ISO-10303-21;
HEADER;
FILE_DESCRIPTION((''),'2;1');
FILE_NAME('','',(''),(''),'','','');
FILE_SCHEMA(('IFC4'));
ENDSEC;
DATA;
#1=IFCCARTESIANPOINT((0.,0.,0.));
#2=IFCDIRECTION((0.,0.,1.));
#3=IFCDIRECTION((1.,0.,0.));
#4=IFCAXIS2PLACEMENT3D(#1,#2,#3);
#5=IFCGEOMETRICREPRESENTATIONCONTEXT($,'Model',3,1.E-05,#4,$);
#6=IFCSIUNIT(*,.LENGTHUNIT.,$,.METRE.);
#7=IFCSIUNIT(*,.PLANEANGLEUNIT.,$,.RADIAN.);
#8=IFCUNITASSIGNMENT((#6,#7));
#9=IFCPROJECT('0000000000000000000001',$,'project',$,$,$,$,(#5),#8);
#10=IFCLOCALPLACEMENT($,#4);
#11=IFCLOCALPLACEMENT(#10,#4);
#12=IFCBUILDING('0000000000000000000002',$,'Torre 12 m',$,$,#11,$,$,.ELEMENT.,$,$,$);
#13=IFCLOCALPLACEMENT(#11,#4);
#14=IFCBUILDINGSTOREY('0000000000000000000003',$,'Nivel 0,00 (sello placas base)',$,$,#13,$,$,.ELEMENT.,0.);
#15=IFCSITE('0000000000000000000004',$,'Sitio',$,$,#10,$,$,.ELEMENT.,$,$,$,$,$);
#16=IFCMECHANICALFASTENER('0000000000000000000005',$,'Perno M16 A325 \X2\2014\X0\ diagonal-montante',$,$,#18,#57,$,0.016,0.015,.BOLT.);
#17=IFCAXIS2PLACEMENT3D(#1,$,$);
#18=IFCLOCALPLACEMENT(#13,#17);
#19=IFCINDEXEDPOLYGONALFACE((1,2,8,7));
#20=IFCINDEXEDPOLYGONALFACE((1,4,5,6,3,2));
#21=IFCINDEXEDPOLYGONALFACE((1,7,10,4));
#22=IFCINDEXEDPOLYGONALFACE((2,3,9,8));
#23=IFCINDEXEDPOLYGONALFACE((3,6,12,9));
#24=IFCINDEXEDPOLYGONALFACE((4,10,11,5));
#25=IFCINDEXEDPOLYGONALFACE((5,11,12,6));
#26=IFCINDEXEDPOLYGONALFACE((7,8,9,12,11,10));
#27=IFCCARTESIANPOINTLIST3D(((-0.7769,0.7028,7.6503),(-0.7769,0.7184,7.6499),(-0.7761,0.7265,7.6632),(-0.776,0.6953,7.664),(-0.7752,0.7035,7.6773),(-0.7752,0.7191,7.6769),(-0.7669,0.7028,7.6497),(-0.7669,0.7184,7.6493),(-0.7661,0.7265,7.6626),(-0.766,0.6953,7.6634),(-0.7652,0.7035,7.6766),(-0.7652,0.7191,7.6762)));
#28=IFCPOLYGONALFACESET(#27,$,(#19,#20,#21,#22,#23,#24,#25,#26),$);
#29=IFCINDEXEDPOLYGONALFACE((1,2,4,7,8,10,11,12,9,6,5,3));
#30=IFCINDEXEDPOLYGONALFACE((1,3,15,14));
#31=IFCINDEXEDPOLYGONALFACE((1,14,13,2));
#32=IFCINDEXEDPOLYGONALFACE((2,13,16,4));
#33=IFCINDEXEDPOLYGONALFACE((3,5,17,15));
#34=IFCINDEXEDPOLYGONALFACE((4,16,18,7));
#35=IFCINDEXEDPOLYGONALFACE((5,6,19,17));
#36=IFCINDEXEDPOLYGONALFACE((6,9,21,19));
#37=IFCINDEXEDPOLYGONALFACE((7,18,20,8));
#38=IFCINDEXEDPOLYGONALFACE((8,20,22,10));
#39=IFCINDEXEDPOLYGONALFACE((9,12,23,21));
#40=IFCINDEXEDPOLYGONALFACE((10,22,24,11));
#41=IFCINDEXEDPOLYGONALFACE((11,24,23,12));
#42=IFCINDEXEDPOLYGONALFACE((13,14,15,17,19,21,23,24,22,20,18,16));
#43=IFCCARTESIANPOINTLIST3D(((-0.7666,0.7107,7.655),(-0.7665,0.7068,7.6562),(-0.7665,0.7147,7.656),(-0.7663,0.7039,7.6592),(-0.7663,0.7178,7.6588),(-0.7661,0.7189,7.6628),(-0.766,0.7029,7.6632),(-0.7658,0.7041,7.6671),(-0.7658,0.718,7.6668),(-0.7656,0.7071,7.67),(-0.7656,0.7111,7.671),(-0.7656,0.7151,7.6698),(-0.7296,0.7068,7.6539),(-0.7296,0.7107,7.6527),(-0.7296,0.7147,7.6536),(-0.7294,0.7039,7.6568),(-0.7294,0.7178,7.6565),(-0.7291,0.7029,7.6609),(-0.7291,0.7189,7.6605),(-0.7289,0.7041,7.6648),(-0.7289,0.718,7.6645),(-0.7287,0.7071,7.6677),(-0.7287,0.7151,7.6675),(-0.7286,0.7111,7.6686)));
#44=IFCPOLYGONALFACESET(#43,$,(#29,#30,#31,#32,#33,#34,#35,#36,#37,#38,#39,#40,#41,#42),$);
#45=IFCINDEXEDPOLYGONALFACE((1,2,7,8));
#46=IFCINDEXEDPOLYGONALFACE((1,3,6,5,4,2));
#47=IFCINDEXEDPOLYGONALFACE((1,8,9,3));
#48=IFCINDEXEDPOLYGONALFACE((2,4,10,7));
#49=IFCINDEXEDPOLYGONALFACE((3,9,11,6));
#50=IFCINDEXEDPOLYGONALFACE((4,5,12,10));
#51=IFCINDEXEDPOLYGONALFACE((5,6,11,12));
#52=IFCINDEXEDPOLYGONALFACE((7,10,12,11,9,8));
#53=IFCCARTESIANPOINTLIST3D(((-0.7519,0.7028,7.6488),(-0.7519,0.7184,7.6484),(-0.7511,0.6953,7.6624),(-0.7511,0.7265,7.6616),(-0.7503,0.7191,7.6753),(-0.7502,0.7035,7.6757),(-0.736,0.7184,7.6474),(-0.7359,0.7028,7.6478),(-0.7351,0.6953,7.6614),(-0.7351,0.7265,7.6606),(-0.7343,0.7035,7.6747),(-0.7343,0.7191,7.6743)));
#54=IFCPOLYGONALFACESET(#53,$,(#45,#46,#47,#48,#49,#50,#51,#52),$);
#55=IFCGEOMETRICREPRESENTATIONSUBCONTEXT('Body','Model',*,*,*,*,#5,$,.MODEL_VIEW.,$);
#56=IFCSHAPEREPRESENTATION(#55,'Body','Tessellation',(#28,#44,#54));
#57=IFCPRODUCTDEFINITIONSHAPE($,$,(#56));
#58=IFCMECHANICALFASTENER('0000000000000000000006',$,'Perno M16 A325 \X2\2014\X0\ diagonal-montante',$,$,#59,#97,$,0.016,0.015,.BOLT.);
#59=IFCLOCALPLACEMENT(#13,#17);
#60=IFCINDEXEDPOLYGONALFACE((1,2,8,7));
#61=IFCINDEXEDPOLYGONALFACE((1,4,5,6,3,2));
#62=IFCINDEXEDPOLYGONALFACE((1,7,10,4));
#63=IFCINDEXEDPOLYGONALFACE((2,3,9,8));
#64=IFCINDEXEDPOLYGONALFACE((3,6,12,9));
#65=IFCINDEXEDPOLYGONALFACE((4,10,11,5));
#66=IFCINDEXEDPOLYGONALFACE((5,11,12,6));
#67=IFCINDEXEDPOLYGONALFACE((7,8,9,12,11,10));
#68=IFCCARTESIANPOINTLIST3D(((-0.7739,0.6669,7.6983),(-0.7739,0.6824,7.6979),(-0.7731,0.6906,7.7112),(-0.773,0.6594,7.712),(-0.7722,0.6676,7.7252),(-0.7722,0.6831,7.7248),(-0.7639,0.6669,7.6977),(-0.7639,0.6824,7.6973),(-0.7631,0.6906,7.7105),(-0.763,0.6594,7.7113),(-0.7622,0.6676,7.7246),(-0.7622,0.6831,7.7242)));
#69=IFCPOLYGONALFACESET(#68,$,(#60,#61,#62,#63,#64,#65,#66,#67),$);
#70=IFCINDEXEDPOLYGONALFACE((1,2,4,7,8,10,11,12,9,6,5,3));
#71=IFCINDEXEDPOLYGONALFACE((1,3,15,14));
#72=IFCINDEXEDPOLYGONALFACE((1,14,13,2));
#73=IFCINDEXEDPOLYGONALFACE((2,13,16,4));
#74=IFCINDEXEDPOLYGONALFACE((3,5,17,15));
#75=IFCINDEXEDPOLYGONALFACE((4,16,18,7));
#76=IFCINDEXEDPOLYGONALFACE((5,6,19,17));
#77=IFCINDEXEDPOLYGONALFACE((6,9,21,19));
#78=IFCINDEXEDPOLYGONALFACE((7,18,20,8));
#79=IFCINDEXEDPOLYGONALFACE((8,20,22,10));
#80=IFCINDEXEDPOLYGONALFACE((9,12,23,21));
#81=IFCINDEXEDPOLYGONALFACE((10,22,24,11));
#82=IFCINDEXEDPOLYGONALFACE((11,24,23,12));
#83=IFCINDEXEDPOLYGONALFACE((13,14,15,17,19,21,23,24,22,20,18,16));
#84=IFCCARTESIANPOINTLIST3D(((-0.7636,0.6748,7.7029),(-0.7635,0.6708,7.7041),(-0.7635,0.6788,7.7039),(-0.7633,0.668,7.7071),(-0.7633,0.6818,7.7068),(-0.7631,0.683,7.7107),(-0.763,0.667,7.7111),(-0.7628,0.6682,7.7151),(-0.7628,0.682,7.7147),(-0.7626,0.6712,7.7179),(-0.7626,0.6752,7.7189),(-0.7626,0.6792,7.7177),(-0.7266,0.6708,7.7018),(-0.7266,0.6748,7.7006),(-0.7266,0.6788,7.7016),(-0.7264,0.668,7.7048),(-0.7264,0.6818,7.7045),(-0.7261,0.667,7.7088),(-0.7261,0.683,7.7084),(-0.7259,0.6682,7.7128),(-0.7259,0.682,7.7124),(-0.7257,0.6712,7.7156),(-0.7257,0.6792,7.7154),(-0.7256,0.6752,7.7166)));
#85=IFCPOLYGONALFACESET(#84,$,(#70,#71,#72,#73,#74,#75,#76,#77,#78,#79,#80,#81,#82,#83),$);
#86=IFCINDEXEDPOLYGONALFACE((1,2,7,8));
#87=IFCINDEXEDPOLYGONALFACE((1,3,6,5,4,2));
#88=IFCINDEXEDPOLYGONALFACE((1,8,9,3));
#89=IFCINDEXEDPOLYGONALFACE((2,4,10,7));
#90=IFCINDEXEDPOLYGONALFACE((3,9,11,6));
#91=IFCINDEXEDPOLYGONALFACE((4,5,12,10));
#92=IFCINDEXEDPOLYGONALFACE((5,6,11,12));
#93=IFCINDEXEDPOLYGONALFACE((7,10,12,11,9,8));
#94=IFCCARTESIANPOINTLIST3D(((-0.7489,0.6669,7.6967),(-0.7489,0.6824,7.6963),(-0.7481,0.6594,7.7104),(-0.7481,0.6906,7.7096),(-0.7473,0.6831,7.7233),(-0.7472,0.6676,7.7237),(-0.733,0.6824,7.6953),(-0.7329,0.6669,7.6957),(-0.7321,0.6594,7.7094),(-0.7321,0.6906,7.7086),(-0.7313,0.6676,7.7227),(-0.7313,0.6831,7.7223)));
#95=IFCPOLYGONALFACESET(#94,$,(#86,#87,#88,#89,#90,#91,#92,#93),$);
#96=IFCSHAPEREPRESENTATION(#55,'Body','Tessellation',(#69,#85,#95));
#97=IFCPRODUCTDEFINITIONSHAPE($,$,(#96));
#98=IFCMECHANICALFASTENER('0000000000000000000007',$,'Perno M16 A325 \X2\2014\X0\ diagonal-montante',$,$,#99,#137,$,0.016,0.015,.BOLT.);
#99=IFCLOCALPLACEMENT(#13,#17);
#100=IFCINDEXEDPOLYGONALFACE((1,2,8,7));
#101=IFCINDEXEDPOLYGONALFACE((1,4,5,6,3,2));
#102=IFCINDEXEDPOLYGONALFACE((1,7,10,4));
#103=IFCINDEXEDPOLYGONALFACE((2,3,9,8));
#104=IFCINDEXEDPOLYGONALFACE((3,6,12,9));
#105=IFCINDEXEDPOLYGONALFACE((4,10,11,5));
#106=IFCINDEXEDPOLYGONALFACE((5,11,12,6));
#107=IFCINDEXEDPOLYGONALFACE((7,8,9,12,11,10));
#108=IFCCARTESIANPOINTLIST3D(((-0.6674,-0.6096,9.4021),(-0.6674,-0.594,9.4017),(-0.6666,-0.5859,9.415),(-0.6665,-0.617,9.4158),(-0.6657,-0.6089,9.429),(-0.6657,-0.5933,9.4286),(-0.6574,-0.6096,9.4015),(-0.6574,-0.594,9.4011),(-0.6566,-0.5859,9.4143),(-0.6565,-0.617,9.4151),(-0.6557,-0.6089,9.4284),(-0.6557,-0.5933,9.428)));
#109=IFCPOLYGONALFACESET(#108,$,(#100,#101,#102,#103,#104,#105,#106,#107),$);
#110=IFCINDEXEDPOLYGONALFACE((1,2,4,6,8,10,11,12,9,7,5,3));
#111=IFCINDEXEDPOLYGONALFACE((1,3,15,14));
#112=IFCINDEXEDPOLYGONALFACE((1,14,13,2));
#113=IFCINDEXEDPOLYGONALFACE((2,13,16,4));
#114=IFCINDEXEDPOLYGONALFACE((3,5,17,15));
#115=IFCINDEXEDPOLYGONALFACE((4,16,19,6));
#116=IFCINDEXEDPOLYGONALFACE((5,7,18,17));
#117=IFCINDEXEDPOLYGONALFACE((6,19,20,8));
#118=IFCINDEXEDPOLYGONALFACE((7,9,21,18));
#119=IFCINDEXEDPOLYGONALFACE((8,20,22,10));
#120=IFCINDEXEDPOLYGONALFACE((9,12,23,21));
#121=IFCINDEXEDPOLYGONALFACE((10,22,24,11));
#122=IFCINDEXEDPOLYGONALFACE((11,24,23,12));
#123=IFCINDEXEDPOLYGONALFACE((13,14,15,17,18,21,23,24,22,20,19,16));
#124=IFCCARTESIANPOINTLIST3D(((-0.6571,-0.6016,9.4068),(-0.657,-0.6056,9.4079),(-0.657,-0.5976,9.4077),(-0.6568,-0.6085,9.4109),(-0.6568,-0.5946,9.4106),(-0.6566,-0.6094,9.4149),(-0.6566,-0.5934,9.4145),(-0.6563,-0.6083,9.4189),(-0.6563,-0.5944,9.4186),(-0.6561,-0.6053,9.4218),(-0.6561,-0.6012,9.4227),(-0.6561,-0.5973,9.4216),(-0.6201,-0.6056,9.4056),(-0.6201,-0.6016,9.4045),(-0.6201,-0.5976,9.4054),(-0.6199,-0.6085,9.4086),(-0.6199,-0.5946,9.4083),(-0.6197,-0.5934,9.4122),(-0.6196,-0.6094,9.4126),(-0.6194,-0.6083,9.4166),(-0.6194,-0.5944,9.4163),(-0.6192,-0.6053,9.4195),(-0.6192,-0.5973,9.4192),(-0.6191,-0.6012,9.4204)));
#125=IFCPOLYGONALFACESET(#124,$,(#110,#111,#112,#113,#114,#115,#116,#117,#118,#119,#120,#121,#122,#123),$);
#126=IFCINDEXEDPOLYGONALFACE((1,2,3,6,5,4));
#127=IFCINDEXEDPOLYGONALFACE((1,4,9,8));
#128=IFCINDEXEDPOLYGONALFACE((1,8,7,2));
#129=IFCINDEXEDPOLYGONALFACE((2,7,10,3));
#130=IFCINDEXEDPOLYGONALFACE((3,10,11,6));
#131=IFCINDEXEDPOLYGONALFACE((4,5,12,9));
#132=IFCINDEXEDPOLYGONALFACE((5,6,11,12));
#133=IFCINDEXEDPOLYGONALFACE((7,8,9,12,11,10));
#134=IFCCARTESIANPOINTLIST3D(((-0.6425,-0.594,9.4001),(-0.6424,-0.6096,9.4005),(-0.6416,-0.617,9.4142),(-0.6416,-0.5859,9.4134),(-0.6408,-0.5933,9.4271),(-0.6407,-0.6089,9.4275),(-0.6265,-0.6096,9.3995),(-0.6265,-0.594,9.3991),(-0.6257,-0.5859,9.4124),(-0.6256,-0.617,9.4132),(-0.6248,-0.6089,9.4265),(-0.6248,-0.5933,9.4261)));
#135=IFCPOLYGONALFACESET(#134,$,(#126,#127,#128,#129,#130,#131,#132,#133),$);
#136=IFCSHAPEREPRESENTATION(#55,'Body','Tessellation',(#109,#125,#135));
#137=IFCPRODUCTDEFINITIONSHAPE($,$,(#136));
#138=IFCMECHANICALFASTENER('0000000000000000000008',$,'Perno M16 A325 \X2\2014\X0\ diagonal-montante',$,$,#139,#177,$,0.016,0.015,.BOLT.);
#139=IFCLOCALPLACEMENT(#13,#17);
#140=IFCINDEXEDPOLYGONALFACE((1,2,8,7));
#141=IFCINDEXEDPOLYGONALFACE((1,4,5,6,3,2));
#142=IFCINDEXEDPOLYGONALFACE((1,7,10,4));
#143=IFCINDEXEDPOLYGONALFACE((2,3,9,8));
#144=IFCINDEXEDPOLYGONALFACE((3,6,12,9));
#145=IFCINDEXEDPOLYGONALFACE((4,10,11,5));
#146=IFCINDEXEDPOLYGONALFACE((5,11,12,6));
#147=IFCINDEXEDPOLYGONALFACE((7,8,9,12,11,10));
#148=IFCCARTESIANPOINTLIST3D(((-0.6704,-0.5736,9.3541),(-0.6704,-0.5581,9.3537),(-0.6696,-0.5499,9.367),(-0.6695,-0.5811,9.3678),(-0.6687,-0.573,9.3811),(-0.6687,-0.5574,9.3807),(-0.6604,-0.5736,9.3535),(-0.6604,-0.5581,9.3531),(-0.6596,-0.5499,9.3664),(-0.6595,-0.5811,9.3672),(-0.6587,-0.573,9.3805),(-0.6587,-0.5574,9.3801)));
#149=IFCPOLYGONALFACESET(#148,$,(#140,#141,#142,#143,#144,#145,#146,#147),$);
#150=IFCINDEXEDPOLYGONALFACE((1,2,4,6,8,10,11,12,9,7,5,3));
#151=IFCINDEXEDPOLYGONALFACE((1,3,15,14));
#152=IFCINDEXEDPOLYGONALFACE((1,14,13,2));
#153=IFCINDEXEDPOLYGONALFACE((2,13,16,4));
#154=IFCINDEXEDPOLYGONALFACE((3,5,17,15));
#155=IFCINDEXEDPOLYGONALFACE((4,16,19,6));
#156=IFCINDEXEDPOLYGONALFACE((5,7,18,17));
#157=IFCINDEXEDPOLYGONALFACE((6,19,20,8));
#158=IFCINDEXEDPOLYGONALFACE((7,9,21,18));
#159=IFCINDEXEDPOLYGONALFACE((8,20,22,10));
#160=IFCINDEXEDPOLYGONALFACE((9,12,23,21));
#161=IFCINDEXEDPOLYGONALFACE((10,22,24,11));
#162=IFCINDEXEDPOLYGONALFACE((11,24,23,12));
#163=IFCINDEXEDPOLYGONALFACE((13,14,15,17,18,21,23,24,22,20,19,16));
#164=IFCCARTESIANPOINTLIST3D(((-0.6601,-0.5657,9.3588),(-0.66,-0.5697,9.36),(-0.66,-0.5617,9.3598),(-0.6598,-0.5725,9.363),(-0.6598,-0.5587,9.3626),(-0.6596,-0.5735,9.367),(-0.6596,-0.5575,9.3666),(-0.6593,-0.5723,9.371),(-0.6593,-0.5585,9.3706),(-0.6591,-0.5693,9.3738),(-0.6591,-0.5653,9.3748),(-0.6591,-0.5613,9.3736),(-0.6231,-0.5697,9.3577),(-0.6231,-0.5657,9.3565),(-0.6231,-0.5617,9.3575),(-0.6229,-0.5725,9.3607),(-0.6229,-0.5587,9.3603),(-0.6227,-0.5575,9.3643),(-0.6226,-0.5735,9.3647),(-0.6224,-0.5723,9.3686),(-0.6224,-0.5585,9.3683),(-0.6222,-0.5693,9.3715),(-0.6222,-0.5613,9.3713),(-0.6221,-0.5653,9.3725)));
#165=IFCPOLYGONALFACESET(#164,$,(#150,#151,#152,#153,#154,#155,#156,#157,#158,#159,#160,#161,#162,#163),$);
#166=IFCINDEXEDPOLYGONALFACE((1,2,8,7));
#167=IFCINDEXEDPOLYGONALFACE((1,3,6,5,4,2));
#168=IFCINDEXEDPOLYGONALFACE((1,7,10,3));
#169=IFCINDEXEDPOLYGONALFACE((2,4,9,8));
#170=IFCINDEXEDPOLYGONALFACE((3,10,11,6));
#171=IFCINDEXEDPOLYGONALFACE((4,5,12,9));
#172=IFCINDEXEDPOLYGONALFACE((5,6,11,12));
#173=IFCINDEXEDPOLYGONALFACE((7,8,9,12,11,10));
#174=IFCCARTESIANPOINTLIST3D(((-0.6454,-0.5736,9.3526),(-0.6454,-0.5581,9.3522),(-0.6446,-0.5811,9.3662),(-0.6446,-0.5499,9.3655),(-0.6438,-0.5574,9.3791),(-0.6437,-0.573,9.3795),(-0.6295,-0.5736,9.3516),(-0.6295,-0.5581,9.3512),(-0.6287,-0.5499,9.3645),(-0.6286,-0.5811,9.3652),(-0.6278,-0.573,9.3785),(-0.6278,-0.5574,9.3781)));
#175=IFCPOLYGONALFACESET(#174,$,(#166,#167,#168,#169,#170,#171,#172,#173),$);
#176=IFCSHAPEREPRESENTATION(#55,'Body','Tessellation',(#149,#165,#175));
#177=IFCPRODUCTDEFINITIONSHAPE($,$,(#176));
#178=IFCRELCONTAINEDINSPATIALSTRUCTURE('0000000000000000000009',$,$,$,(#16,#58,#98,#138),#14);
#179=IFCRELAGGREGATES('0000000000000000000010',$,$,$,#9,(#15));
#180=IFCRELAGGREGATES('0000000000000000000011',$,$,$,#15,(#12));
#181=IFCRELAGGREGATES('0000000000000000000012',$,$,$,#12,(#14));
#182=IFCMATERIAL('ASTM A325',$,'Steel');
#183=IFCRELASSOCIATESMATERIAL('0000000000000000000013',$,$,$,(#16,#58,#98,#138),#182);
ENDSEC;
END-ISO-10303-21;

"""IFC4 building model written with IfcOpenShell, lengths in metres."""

from ifc_helpers import new_model, si_unit, frame, origin_with_axes, place, context, subcontext, project, spatial, polyline, outline, extrude, material, element, save


model = new_model("IFC4")

# Units and contexts
model_context = context("Model", 3, precision=1e-05, world=origin_with_axes())
body_context = subcontext(model_context, "Body", "Model", "MODEL_VIEW")
ifc_project = project(units=[si_unit("LENGTHUNIT", "METRE"), si_unit("PLANEANGLEUNIT", "RADIAN")], contexts=[model_context])

# Site, building, storey
site_placement = place(None, origin_with_axes())
site = spatial("IfcSite", under=ifc_project, at=site_placement, Name="Sitio", CompositionType="ELEMENT")
building_placement = place(site_placement, origin_with_axes())
building = spatial("IfcBuilding", under=site, at=building_placement, Name="Torre 12 m", CompositionType="ELEMENT")
storey_placement = place(building_placement, origin_with_axes())
storey = spatial("IfcBuildingStorey", under=building, at=storey_placement, Name="Nivel 0,00 (sello placas base)", CompositionType="ELEMENT", Elevation=0.0)

# Shared definitions
placement = place(storey_placement, origin_with_axes())

# Mechanical fasteners
ifc_material_1 = material(Name="ASTM A325", Category="Steel")
element("IfcMechanicalFastener", 1, at=placement, inside=storey, material=ifc_material_1, Name="Perno M16 A325 — diagonal-montante", NominalDiameter=0.016, NominalLength=0.015, PredefinedType="BOLT", context=body_context, shape_type="SweptSolid", body=[
    extrude(outline(polyline([(0.0135, 0.0078), (0.0, 0.0156), (-0.0135, 0.0078), (-0.0135, -0.0078), (0.0, -0.0156), (0.0135, -0.0078), (0.0135, 0.0078)])), frame((-0.776, 0.7109, 7.6636), z_axis=(0.998053, 0.0, -0.062378), x_axis=(0.032557, -0.85299, 0.52091)), (0.0, 0.0, 1.0), 0.01),
    extrude(outline(polyline([(0.008, 0.0), (0.0069, 0.004), (0.004, 0.0069), (0.0, 0.008), (-0.004, 0.0069), (-0.0069, 0.004), (-0.008, 0.0), (-0.0069, -0.004), (-0.004, -0.0069), (0.0, -0.008), (0.004, -0.0069), (0.0069, -0.004), (0.008, 0.0)])), frame((-0.7661, 0.7109, 7.663), z_axis=(0.998053, 0.0, -0.062378), x_axis=(0.032557, -0.85299, 0.52091)), (0.0, 0.0, 1.0), 0.037),
    extrude(outline(polyline([(0.0135, 0.0078), (0.0, 0.0156), (-0.0135, 0.0078), (-0.0135, -0.0078), (0.0, -0.0156), (0.0135, -0.0078), (0.0135, 0.0078)])), frame((-0.7511, 0.7109, 7.662), z_axis=(0.998053, 0.0, -0.062378), x_axis=(0.032557, -0.85299, 0.52091)), (0.0, 0.0, 1.0), 0.016),
])
element("IfcMechanicalFastener", 2, at=placement, inside=storey, material=ifc_material_1, Name="Perno M16 A325 — diagonal-montante", NominalDiameter=0.016, NominalLength=0.015, PredefinedType="BOLT", context=body_context, shape_type="SweptSolid", body=[
    extrude(outline(polyline([(0.0135, 0.0078), (0.0, 0.0156), (-0.0135, 0.0078), (-0.0135, -0.0078), (0.0, -0.0156), (0.0135, -0.0078), (0.0135, 0.0078)])), frame((-0.773, 0.675, 7.7116), z_axis=(0.998053, 0.0, -0.062378), x_axis=(0.032557, -0.85299, 0.52091)), (0.0, 0.0, 1.0), 0.01),
    extrude(outline(polyline([(0.008, 0.0), (0.0069, 0.004), (0.004, 0.0069), (0.0, 0.008), (-0.004, 0.0069), (-0.0069, 0.004), (-0.008, 0.0), (-0.0069, -0.004), (-0.004, -0.0069), (0.0, -0.008), (0.004, -0.0069), (0.0069, -0.004), (0.008, 0.0)])), frame((-0.7631, 0.675, 7.7109), z_axis=(0.998053, 0.0, -0.062378), x_axis=(0.032557, -0.85299, 0.52091)), (0.0, 0.0, 1.0), 0.037),
    extrude(outline(polyline([(0.0135, 0.0078), (0.0, 0.0156), (-0.0135, 0.0078), (-0.0135, -0.0078), (0.0, -0.0156), (0.0135, -0.0078), (0.0135, 0.0078)])), frame((-0.7481, 0.675, 7.71), z_axis=(0.998053, 0.0, -0.062378), x_axis=(0.032557, -0.85299, 0.52091)), (0.0, 0.0, 1.0), 0.016),
])
element("IfcMechanicalFastener", 3, at=placement, inside=storey, material=ifc_material_1, Name="Perno M16 A325 — diagonal-montante", NominalDiameter=0.016, NominalLength=0.015, PredefinedType="BOLT", context=body_context, shape_type="SweptSolid", body=[
    extrude(outline(polyline([(0.0135, 0.0078), (0.0, 0.0156), (-0.0135, 0.0078), (-0.0135, -0.0078), (0.0, -0.0156), (0.0135, -0.0078), (0.0135, 0.0078)])), frame((-0.6665, -0.6014, 9.4154), z_axis=(0.998053, 0.0, -0.062378), x_axis=(0.032557, -0.85299, 0.52091)), (0.0, 0.0, 1.0), 0.01),
    extrude(outline(polyline([(0.008, 0.0), (0.0069, 0.004), (0.004, 0.0069), (0.0, 0.008), (-0.004, 0.0069), (-0.0069, 0.004), (-0.008, 0.0), (-0.0069, -0.004), (-0.004, -0.0069), (0.0, -0.008), (0.004, -0.0069), (0.0069, -0.004), (0.008, 0.0)])), frame((-0.6566, -0.6014, 9.4147), z_axis=(0.998053, 0.0, -0.062378), x_axis=(0.032557, -0.85299, 0.52091)), (0.0, 0.0, 1.0), 0.037),
    extrude(outline(polyline([(0.0135, 0.0078), (0.0, 0.0156), (-0.0135, 0.0078), (-0.0135, -0.0078), (0.0, -0.0156), (0.0135, -0.0078), (0.0135, 0.0078)])), frame((-0.6416, -0.6014, 9.4138), z_axis=(0.998053, 0.0, -0.062378), x_axis=(0.032557, -0.85299, 0.52091)), (0.0, 0.0, 1.0), 0.016),
])
element("IfcMechanicalFastener", 4, at=placement, inside=storey, material=ifc_material_1, Name="Perno M16 A325 — diagonal-montante", NominalDiameter=0.016, NominalLength=0.015, PredefinedType="BOLT", context=body_context, shape_type="SweptSolid", body=[
    extrude(outline(polyline([(0.0135, 0.0078), (0.0, 0.0156), (-0.0135, 0.0078), (-0.0135, -0.0078), (0.0, -0.0156), (0.0135, -0.0078), (0.0135, 0.0078)])), frame((-0.6695, -0.5655, 9.3674), z_axis=(0.998053, 0.0, -0.062378), x_axis=(0.032557, -0.85299, 0.52091)), (0.0, 0.0, 1.0), 0.01),
    extrude(outline(polyline([(0.008, 0.0), (0.0069, 0.004), (0.004, 0.0069), (0.0, 0.008), (-0.004, 0.0069), (-0.0069, 0.004), (-0.008, 0.0), (-0.0069, -0.004), (-0.004, -0.0069), (0.0, -0.008), (0.004, -0.0069), (0.0069, -0.004), (0.008, 0.0)])), frame((-0.6596, -0.5655, 9.3668), z_axis=(0.998053, 0.0, -0.062378), x_axis=(0.032557, -0.85299, 0.52091)), (0.0, 0.0, 1.0), 0.037),
    extrude(outline(polyline([(0.0135, 0.0078), (0.0, 0.0156), (-0.0135, 0.0078), (-0.0135, -0.0078), (0.0, -0.0156), (0.0135, -0.0078), (0.0135, 0.0078)])), frame((-0.6446, -0.5655, 9.3659), z_axis=(0.998053, 0.0, -0.062378), x_axis=(0.032557, -0.85299, 0.52091)), (0.0, 0.0, 1.0), 0.016),
])

save(model, "model.ifc")
